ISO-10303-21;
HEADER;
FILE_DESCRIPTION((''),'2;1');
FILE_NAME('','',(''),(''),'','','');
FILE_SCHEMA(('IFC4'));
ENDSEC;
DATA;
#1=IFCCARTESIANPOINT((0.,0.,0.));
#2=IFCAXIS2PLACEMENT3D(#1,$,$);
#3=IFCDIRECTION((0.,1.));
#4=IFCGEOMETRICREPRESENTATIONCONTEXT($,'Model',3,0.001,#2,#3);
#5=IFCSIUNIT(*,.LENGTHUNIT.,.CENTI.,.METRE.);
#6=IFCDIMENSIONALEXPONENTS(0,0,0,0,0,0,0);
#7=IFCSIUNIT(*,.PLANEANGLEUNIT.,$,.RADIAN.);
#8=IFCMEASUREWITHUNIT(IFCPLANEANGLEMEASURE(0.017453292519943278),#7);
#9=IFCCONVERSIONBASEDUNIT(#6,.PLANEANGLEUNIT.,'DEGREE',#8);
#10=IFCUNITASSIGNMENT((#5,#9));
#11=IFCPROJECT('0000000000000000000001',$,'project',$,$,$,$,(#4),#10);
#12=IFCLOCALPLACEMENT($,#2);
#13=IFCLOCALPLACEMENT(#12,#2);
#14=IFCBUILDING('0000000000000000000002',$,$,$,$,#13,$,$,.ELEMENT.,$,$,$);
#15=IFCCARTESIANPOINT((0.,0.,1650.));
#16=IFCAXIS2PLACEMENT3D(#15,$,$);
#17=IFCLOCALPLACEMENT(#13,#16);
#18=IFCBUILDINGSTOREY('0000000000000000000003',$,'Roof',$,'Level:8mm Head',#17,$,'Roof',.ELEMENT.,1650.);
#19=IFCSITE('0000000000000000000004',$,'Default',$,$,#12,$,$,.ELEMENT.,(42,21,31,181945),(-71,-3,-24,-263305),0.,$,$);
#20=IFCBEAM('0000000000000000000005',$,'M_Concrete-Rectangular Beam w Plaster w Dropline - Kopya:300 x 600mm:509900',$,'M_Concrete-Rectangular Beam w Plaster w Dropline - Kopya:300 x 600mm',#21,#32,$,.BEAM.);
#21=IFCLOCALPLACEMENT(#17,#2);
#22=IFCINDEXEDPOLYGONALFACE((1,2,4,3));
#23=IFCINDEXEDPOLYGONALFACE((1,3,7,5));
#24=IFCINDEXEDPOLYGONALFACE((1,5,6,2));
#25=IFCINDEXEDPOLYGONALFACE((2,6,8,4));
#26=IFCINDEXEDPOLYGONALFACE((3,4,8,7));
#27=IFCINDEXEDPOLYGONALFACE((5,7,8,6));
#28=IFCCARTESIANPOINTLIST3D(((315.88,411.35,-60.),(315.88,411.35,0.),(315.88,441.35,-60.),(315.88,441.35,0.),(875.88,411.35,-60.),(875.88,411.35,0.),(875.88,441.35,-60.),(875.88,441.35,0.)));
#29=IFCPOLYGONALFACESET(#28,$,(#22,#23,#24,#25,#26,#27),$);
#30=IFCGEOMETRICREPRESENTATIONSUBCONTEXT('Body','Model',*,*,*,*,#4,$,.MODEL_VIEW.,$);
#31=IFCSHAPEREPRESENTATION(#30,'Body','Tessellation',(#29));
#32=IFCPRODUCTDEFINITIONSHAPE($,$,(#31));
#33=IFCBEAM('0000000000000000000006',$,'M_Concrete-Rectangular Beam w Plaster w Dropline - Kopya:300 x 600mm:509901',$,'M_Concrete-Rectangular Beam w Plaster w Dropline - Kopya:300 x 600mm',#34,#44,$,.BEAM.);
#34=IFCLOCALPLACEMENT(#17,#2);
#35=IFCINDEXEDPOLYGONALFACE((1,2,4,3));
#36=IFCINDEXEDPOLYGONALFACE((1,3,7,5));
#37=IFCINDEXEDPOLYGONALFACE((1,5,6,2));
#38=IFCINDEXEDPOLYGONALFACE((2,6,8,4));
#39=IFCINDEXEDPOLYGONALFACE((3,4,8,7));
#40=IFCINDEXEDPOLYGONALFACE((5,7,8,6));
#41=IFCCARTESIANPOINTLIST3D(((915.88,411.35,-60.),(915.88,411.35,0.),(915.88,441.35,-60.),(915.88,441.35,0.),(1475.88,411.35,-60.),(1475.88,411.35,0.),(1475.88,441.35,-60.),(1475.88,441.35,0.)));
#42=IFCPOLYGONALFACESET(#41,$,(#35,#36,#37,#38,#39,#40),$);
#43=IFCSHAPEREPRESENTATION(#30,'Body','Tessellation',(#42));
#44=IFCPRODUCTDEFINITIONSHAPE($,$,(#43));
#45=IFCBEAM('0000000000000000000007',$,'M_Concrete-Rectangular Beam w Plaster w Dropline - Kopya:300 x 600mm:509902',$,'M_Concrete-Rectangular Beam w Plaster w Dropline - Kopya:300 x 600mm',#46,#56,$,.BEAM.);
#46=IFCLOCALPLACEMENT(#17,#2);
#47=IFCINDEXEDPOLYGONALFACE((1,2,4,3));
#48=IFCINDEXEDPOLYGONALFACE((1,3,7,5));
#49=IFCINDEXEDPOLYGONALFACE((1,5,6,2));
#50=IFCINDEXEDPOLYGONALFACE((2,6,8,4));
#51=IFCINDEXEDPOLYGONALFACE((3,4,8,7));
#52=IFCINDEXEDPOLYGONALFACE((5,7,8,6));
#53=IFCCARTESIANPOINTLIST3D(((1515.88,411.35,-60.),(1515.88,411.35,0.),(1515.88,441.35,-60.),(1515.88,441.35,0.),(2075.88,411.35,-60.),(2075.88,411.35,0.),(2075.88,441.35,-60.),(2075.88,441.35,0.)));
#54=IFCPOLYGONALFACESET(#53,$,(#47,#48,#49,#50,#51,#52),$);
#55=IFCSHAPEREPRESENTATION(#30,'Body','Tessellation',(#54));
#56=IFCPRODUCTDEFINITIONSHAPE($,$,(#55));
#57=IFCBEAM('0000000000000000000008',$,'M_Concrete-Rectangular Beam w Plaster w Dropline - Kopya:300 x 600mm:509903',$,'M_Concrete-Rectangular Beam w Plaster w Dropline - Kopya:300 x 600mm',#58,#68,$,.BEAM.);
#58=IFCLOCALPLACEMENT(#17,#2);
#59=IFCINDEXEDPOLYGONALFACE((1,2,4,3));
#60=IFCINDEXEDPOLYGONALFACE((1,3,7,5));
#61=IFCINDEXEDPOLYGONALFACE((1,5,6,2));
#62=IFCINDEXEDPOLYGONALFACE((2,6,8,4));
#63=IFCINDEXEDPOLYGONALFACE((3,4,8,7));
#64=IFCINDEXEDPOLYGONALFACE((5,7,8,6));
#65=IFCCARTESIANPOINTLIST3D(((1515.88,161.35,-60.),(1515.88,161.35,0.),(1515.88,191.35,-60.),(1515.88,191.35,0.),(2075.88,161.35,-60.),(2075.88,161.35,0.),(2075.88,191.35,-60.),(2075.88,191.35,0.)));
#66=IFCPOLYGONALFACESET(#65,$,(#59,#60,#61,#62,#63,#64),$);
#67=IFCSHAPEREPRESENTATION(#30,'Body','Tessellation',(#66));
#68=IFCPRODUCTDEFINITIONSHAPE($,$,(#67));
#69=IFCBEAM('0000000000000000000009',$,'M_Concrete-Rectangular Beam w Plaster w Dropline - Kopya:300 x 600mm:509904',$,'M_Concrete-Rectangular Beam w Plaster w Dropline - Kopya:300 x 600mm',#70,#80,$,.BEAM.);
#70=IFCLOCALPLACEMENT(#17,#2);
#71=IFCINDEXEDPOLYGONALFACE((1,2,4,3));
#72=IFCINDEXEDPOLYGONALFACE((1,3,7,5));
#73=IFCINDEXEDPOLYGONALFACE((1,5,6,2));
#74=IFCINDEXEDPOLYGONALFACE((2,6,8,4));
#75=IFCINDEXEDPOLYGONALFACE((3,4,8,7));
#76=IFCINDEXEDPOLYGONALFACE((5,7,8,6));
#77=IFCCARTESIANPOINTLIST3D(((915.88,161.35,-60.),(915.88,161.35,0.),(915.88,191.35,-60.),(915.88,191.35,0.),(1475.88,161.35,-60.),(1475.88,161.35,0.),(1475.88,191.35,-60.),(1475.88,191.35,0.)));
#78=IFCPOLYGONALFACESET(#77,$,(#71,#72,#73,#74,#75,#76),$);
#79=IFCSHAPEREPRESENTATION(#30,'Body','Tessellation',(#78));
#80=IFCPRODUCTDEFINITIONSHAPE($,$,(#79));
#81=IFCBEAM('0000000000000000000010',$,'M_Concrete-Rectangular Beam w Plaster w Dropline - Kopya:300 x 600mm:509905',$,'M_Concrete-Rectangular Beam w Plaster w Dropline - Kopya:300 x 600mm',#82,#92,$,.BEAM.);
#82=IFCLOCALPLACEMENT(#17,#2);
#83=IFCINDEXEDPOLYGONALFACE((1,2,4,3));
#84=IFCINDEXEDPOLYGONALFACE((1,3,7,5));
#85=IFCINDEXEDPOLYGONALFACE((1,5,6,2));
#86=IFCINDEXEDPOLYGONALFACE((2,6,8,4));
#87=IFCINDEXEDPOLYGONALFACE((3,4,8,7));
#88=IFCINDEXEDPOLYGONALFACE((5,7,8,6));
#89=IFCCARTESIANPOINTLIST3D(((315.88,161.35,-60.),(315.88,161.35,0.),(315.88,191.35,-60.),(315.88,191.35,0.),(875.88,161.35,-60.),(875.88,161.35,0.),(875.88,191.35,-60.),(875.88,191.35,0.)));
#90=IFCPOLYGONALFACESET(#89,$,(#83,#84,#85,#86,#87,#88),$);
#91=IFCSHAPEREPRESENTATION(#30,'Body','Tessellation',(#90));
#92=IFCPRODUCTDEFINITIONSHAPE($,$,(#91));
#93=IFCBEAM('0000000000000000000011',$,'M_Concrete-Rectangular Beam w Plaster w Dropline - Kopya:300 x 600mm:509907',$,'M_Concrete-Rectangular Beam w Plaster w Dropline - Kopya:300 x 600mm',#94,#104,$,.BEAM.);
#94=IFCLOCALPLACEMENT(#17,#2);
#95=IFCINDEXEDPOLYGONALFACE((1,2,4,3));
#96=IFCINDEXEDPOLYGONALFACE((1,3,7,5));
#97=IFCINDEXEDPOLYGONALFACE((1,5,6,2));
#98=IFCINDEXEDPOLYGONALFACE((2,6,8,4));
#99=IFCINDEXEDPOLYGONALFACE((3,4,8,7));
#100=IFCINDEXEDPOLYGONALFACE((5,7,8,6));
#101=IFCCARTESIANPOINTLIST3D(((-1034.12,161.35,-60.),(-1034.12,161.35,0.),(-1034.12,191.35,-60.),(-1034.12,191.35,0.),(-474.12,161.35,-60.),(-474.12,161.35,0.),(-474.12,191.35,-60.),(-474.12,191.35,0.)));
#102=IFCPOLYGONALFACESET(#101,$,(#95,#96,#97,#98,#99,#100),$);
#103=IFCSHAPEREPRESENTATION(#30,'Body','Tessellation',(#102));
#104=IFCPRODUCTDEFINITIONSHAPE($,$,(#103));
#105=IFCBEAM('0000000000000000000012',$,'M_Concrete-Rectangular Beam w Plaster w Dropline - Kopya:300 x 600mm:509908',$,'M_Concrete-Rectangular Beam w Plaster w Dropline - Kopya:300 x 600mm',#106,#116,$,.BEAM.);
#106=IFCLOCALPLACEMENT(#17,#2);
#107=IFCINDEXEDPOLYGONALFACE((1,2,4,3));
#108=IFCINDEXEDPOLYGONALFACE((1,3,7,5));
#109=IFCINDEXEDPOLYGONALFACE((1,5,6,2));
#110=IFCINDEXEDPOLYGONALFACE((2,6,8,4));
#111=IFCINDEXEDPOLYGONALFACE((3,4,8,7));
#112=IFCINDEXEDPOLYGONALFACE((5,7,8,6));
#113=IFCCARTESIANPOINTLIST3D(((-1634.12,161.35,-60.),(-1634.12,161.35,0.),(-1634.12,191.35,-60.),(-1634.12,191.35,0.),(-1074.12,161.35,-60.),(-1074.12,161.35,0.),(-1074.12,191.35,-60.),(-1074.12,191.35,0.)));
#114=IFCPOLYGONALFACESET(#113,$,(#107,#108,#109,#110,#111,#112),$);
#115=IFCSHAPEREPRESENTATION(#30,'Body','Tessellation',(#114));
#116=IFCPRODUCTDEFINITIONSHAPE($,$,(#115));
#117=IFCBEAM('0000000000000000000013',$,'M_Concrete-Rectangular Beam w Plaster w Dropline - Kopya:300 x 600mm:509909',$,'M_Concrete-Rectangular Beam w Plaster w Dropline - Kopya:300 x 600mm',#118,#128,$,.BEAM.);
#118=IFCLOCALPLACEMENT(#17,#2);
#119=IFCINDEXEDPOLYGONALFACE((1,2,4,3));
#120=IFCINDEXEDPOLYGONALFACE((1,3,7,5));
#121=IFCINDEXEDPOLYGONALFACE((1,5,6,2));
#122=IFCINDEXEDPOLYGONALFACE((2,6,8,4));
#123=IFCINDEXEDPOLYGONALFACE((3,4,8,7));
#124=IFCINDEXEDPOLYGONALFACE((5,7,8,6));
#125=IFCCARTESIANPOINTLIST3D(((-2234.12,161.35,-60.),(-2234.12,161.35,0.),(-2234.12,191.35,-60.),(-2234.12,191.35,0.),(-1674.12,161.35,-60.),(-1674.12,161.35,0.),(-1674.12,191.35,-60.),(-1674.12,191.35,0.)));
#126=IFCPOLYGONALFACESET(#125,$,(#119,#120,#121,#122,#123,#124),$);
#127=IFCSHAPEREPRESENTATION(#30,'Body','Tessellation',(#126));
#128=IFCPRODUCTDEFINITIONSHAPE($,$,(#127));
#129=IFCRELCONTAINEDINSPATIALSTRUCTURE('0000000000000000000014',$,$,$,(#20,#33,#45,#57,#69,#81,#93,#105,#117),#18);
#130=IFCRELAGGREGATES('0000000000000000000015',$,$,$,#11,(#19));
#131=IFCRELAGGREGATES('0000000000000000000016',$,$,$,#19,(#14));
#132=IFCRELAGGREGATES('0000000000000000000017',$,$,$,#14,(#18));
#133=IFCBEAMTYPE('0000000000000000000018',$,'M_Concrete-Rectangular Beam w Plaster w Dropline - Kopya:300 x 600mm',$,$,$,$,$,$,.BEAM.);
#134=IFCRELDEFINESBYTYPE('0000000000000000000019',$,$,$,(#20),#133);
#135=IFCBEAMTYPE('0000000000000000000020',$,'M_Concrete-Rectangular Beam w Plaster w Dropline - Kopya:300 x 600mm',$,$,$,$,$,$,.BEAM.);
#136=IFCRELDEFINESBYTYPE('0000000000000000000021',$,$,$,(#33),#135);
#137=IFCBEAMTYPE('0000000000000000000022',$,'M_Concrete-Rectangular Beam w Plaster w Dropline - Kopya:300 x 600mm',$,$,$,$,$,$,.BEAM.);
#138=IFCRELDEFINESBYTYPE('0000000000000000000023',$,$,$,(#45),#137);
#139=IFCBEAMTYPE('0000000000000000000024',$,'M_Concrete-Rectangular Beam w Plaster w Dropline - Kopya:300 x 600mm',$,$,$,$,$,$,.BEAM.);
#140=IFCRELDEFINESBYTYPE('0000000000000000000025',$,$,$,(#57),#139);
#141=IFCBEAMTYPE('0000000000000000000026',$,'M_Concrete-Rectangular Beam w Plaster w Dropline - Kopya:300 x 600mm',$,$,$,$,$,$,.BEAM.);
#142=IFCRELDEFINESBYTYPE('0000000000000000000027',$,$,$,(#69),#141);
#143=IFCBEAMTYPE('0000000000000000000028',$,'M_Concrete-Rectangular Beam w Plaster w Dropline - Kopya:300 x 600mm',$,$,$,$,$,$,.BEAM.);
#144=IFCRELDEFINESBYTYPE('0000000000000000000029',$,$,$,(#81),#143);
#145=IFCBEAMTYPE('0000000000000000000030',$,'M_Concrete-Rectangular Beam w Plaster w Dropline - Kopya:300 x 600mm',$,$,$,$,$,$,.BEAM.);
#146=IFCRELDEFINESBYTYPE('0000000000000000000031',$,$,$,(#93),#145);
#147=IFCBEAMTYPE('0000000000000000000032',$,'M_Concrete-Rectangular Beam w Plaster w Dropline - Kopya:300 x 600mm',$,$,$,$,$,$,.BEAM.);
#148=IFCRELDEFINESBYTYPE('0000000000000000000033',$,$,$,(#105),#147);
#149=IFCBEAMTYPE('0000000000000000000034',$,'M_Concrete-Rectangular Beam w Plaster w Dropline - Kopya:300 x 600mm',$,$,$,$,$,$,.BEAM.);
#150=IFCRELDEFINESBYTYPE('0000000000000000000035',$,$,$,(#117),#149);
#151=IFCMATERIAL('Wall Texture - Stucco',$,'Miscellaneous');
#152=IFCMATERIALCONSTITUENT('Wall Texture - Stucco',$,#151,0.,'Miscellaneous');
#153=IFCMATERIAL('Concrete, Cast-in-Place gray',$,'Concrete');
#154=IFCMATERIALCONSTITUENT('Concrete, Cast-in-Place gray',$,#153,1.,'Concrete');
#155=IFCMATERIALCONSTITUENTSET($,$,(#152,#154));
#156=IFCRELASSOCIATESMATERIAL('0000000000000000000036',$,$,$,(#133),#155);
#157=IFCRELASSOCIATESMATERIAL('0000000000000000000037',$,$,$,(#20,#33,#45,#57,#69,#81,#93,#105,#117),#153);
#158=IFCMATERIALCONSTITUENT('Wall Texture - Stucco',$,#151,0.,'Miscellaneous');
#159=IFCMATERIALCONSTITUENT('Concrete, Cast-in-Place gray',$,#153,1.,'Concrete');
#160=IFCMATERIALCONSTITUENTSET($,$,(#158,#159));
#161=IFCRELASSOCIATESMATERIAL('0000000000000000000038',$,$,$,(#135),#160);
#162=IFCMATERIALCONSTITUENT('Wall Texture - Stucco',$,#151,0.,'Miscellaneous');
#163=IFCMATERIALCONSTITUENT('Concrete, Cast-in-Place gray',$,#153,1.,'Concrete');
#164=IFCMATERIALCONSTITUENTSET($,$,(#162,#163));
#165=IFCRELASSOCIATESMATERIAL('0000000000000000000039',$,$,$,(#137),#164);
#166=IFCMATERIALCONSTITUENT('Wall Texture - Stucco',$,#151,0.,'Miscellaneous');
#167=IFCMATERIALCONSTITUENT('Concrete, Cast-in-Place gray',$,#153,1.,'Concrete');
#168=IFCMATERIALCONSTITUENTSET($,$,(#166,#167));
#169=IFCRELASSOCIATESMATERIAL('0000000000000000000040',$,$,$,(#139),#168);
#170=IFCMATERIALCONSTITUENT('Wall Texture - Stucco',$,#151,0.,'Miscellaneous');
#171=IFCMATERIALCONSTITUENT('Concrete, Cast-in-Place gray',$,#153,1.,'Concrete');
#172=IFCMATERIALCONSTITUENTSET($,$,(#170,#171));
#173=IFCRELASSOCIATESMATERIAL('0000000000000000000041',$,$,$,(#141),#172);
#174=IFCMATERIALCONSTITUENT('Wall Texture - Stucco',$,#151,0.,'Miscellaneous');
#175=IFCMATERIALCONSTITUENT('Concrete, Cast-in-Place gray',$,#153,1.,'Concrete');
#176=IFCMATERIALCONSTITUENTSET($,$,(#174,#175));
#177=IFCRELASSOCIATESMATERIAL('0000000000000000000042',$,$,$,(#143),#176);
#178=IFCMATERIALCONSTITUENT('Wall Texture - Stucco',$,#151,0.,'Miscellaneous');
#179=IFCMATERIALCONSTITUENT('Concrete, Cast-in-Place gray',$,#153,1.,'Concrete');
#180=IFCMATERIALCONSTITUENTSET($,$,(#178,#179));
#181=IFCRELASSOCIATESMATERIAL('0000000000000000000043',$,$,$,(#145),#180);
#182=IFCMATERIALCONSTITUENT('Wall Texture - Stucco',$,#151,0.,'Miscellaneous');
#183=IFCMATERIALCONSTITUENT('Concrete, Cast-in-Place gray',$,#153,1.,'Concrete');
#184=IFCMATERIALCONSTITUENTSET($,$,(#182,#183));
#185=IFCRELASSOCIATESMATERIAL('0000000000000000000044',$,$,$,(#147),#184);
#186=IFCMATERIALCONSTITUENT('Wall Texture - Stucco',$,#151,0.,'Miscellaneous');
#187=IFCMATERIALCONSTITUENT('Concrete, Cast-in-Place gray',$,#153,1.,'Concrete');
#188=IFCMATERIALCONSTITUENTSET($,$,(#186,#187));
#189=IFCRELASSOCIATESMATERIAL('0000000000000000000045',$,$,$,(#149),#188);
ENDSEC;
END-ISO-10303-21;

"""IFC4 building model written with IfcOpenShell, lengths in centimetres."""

from ifc_helpers import new_model, entity, si_unit, converted_unit, direction, frame, origin, place, context, subcontext, project, spatial, indexed_curve, outline, extrude, source, transform, mapped, material, constituent, constituent_set, type_object, type_shapes, element, save


model = new_model("IFC4")

# Units and contexts
model_context = context("Model", 3, precision=0.001, world=origin(), true_north=direction((0.0, 1.0)))
body_context = subcontext(model_context, "Body", "Model", "MODEL_VIEW")
ifc_project = project(units=[si_unit("LENGTHUNIT", "METRE", prefix="CENTI"), converted_unit("PLANEANGLEUNIT", "DEGREE", entity("IfcPlaneAngleMeasure", 0.017453292519943278), si_unit("PLANEANGLEUNIT", "RADIAN"), dimensions=[0, 0, 0, 0, 0, 0, 0])], contexts=[model_context])

# Site, building, storey
site_placement = place(None, origin())
site = spatial("IfcSite", under=ifc_project, at=site_placement, Name="Default", CompositionType="ELEMENT", RefLatitude=(42, 21, 31, 181945), RefLongitude=(-71, -3, -24, -263305), RefElevation=0.0)
building_placement = place(site_placement, origin())
building = spatial("IfcBuilding", under=site, at=building_placement, CompositionType="ELEMENT")
storey_placement = place(building_placement, frame((0.0, 0.0, 1650.0)))
storey = spatial("IfcBuildingStorey", under=building, at=storey_placement, Name="Roof", ObjectType="Level:8mm Head", LongName="Roof", CompositionType="ELEMENT", Elevation=1650.0)

# Beams
ifc_material_1 = material(Name="Concrete, Cast-in-Place gray", Category="Concrete")
ifc_material_2 = material(Name="Wall Texture - Stucco", Category="Miscellaneous")
ifc_constituent_1 = constituent(ifc_material_2, Name="Wall Texture - Stucco", Category="Miscellaneous", fraction=0.0)
ifc_constituent_2 = constituent(ifc_material_1, Name="Concrete, Cast-in-Place gray", Category="Concrete", fraction=1.0)
ifc_constituent_set_1 = constituent_set(constituents=[ifc_constituent_1, ifc_constituent_2])
beam_type_1 = type_object("IfcBeamType", Name="M_Concrete-Rectangular Beam w Plaster w Dropline - Kopya:300 x 600mm", PredefinedType="BEAM", material=ifc_constituent_set_1)
shared_shape_1 = source(origin(), body_context, "Body", "SweptSolid", [
    extrude(outline(indexed_curve([(-30.0, -15.0), (30.0, -15.0), (30.0, 15.0), (-30.0, 15.0), (-30.0, -15.0)], self_intersect=False)), frame((315.88, 426.35, 1620.0), z_axis=(1.0, 0.0, 0.0), x_axis=(0.0, 0.0, -1.0)), (0.0, 0.0, 1.0), 560.0),
])
type_shapes(beam_type_1, [shared_shape_1])
beam_1_placement = place(storey_placement, frame((0.0, 0.0, -1650.0)))
element("IfcBeam", 1, at=beam_1_placement, inside=storey, type_object=beam_type_1, material=ifc_material_1, Name="M_Concrete-Rectangular Beam w Plaster w Dropline - Kopya:300 x 600mm:509900", ObjectType="M_Concrete-Rectangular Beam w Plaster w Dropline - Kopya:300 x 600mm", PredefinedType="BEAM", context=body_context, shape_type="MappedRepresentation", body=[
    mapped(shared_shape_1, transform((0.0, 0.0, 0.0), scale=1.0)),
])
ifc_constituent_3 = constituent(ifc_material_2, Name="Wall Texture - Stucco", Category="Miscellaneous", fraction=0.0)
ifc_constituent_4 = constituent(ifc_material_1, Name="Concrete, Cast-in-Place gray", Category="Concrete", fraction=1.0)
ifc_constituent_set_2 = constituent_set(constituents=[ifc_constituent_3, ifc_constituent_4])
beam_type_2 = type_object("IfcBeamType", Name="M_Concrete-Rectangular Beam w Plaster w Dropline - Kopya:300 x 600mm", PredefinedType="BEAM", material=ifc_constituent_set_2)
shared_shape_2 = source(origin(), body_context, "Body", "SweptSolid", [
    extrude(outline(indexed_curve([(-30.0, -15.0), (30.0, -15.0), (30.0, 15.0), (-30.0, 15.0), (-30.0, -15.0)], self_intersect=False)), frame((915.88, 426.35, 1620.0), z_axis=(1.0, 0.0, 0.0), x_axis=(0.0, 0.0, -1.0)), (0.0, 0.0, 1.0), 560.0),
])
type_shapes(beam_type_2, [shared_shape_2])
beam_2_placement = place(storey_placement, frame((0.0, 0.0, -1650.0)))
element("IfcBeam", 2, at=beam_2_placement, inside=storey, type_object=beam_type_2, material=ifc_material_1, Name="M_Concrete-Rectangular Beam w Plaster w Dropline - Kopya:300 x 600mm:509901", ObjectType="M_Concrete-Rectangular Beam w Plaster w Dropline - Kopya:300 x 600mm", PredefinedType="BEAM", context=body_context, shape_type="MappedRepresentation", body=[
    mapped(shared_shape_2, transform((0.0, 0.0, 0.0), scale=1.0)),
])
ifc_constituent_5 = constituent(ifc_material_2, Name="Wall Texture - Stucco", Category="Miscellaneous", fraction=0.0)
ifc_constituent_6 = constituent(ifc_material_1, Name="Concrete, Cast-in-Place gray", Category="Concrete", fraction=1.0)
ifc_constituent_set_3 = constituent_set(constituents=[ifc_constituent_5, ifc_constituent_6])
beam_type_3 = type_object("IfcBeamType", Name="M_Concrete-Rectangular Beam w Plaster w Dropline - Kopya:300 x 600mm", PredefinedType="BEAM", material=ifc_constituent_set_3)
shared_shape_3 = source(origin(), body_context, "Body", "SweptSolid", [
    extrude(outline(indexed_curve([(-30.0, -15.0), (30.0, -15.0), (30.0, 15.0), (-30.0, 15.0), (-30.0, -15.0)], self_intersect=False)), frame((1515.88, 426.35, 1620.0), z_axis=(1.0, 0.0, 0.0), x_axis=(0.0, 0.0, -1.0)), (0.0, 0.0, 1.0), 560.0),
])
type_shapes(beam_type_3, [shared_shape_3])
beam_3_placement = place(storey_placement, frame((0.0, 0.0, -1650.0)))
element("IfcBeam", 3, at=beam_3_placement, inside=storey, type_object=beam_type_3, material=ifc_material_1, Name="M_Concrete-Rectangular Beam w Plaster w Dropline - Kopya:300 x 600mm:509902", ObjectType="M_Concrete-Rectangular Beam w Plaster w Dropline - Kopya:300 x 600mm", PredefinedType="BEAM", context=body_context, shape_type="MappedRepresentation", body=[
    mapped(shared_shape_3, transform((0.0, 0.0, 0.0), scale=1.0)),
])
ifc_constituent_7 = constituent(ifc_material_2, Name="Wall Texture - Stucco", Category="Miscellaneous", fraction=0.0)
ifc_constituent_8 = constituent(ifc_material_1, Name="Concrete, Cast-in-Place gray", Category="Concrete", fraction=1.0)
ifc_constituent_set_4 = constituent_set(constituents=[ifc_constituent_7, ifc_constituent_8])
beam_type_4 = type_object("IfcBeamType", Name="M_Concrete-Rectangular Beam w Plaster w Dropline - Kopya:300 x 600mm", PredefinedType="BEAM", material=ifc_constituent_set_4)
shared_shape_4 = source(origin(), body_context, "Body", "SweptSolid", [
    extrude(outline(indexed_curve([(-30.0, -15.0), (30.0, -15.0), (30.0, 15.0), (-30.0, 15.0), (-30.0, -15.0)], self_intersect=False)), frame((2075.88, 176.35, 1620.0), z_axis=(-1.0, 0.0, 0.0), x_axis=(0.0, 0.0, -1.0)), (0.0, 0.0, 1.0), 560.0),
])
type_shapes(beam_type_4, [shared_shape_4])
beam_4_placement = place(storey_placement, frame((0.0, 0.0, -1650.0)))
element("IfcBeam", 4, at=beam_4_placement, inside=storey, type_object=beam_type_4, material=ifc_material_1, Name="M_Concrete-Rectangular Beam w Plaster w Dropline - Kopya:300 x 600mm:509903", ObjectType="M_Concrete-Rectangular Beam w Plaster w Dropline - Kopya:300 x 600mm", PredefinedType="BEAM", context=body_context, shape_type="MappedRepresentation", body=[
    mapped(shared_shape_4, transform((0.0, 0.0, 0.0), scale=1.0)),
])
ifc_constituent_9 = constituent(ifc_material_2, Name="Wall Texture - Stucco", Category="Miscellaneous", fraction=0.0)
ifc_constituent_10 = constituent(ifc_material_1, Name="Concrete, Cast-in-Place gray", Category="Concrete", fraction=1.0)
ifc_constituent_set_5 = constituent_set(constituents=[ifc_constituent_9, ifc_constituent_10])
beam_type_5 = type_object("IfcBeamType", Name="M_Concrete-Rectangular Beam w Plaster w Dropline - Kopya:300 x 600mm", PredefinedType="BEAM", material=ifc_constituent_set_5)
shared_shape_5 = source(origin(), body_context, "Body", "SweptSolid", [
    extrude(outline(indexed_curve([(-30.0, -15.0), (30.0, -15.0), (30.0, 15.0), (-30.0, 15.0), (-30.0, -15.0)], self_intersect=False)), frame((1475.88, 176.35, 1620.0), z_axis=(-1.0, 0.0, 0.0), x_axis=(0.0, 0.0, -1.0)), (0.0, 0.0, 1.0), 560.0),
])
type_shapes(beam_type_5, [shared_shape_5])
beam_5_placement = place(storey_placement, frame((0.0, 0.0, -1650.0)))
element("IfcBeam", 5, at=beam_5_placement, inside=storey, type_object=beam_type_5, material=ifc_material_1, Name="M_Concrete-Rectangular Beam w Plaster w Dropline - Kopya:300 x 600mm:509904", ObjectType="M_Concrete-Rectangular Beam w Plaster w Dropline - Kopya:300 x 600mm", PredefinedType="BEAM", context=body_context, shape_type="MappedRepresentation", body=[
    mapped(shared_shape_5, transform((0.0, 0.0, 0.0), scale=1.0)),
])
ifc_constituent_11 = constituent(ifc_material_2, Name="Wall Texture - Stucco", Category="Miscellaneous", fraction=0.0)
ifc_constituent_12 = constituent(ifc_material_1, Name="Concrete, Cast-in-Place gray", Category="Concrete", fraction=1.0)
ifc_constituent_set_6 = constituent_set(constituents=[ifc_constituent_11, ifc_constituent_12])
beam_type_6 = type_object("IfcBeamType", Name="M_Concrete-Rectangular Beam w Plaster w Dropline - Kopya:300 x 600mm", PredefinedType="BEAM", material=ifc_constituent_set_6)
shared_shape_6 = source(origin(), body_context, "Body", "SweptSolid", [
    extrude(outline(indexed_curve([(-30.0, -15.0), (30.0, -15.0), (30.0, 15.0), (-30.0, 15.0), (-30.0, -15.0)], self_intersect=False)), frame((875.88, 176.35, 1620.0), z_axis=(-1.0, 0.0, 0.0), x_axis=(0.0, 0.0, -1.0)), (0.0, 0.0, 1.0), 560.0),
])
type_shapes(beam_type_6, [shared_shape_6])
beam_6_placement = place(storey_placement, frame((0.0, 0.0, -1650.0)))
element("IfcBeam", 6, at=beam_6_placement, inside=storey, type_object=beam_type_6, material=ifc_material_1, Name="M_Concrete-Rectangular Beam w Plaster w Dropline - Kopya:300 x 600mm:509905", ObjectType="M_Concrete-Rectangular Beam w Plaster w Dropline - Kopya:300 x 600mm", PredefinedType="BEAM", context=body_context, shape_type="MappedRepresentation", body=[
    mapped(shared_shape_6, transform((0.0, 0.0, 0.0), scale=1.0)),
])
ifc_constituent_13 = constituent(ifc_material_2, Name="Wall Texture - Stucco", Category="Miscellaneous", fraction=0.0)
ifc_constituent_14 = constituent(ifc_material_1, Name="Concrete, Cast-in-Place gray", Category="Concrete", fraction=1.0)
ifc_constituent_set_7 = constituent_set(constituents=[ifc_constituent_13, ifc_constituent_14])
beam_type_7 = type_object("IfcBeamType", Name="M_Concrete-Rectangular Beam w Plaster w Dropline - Kopya:300 x 600mm", PredefinedType="BEAM", material=ifc_constituent_set_7)
shared_shape_7 = source(origin(), body_context, "Body", "SweptSolid", [
    extrude(outline(indexed_curve([(-30.0, -15.0), (30.0, -15.0), (30.0, 15.0), (-30.0, 15.0), (-30.0, -15.0)], self_intersect=False)), frame((-474.12, 176.35, 1620.0), z_axis=(-1.0, 0.0, 0.0), x_axis=(0.0, 0.0, -1.0)), (0.0, 0.0, 1.0), 560.0),
])
type_shapes(beam_type_7, [shared_shape_7])
beam_7_placement = place(storey_placement, frame((0.0, 0.0, -1650.0)))
element("IfcBeam", 7, at=beam_7_placement, inside=storey, type_object=beam_type_7, material=ifc_material_1, Name="M_Concrete-Rectangular Beam w Plaster w Dropline - Kopya:300 x 600mm:509907", ObjectType="M_Concrete-Rectangular Beam w Plaster w Dropline - Kopya:300 x 600mm", PredefinedType="BEAM", context=body_context, shape_type="MappedRepresentation", body=[
    mapped(shared_shape_7, transform((0.0, 0.0, 0.0), scale=1.0)),
])
ifc_constituent_15 = constituent(ifc_material_2, Name="Wall Texture - Stucco", Category="Miscellaneous", fraction=0.0)
ifc_constituent_16 = constituent(ifc_material_1, Name="Concrete, Cast-in-Place gray", Category="Concrete", fraction=1.0)
ifc_constituent_set_8 = constituent_set(constituents=[ifc_constituent_15, ifc_constituent_16])
beam_type_8 = type_object("IfcBeamType", Name="M_Concrete-Rectangular Beam w Plaster w Dropline - Kopya:300 x 600mm", PredefinedType="BEAM", material=ifc_constituent_set_8)
shared_shape_8 = source(origin(), body_context, "Body", "SweptSolid", [
    extrude(outline(indexed_curve([(-30.0, -15.0), (30.0, -15.0), (30.0, 15.0), (-30.0, 15.0), (-30.0, -15.0)], self_intersect=False)), frame((-1074.12, 176.35, 1620.0), z_axis=(-1.0, 0.0, 0.0), x_axis=(0.0, 0.0, -1.0)), (0.0, 0.0, 1.0), 560.0),
])
type_shapes(beam_type_8, [shared_shape_8])
beam_8_placement = place(storey_placement, frame((0.0, 0.0, -1650.0)))
element("IfcBeam", 8, at=beam_8_placement, inside=storey, type_object=beam_type_8, material=ifc_material_1, Name="M_Concrete-Rectangular Beam w Plaster w Dropline - Kopya:300 x 600mm:509908", ObjectType="M_Concrete-Rectangular Beam w Plaster w Dropline - Kopya:300 x 600mm", PredefinedType="BEAM", context=body_context, shape_type="MappedRepresentation", body=[
    mapped(shared_shape_8, transform((0.0, 0.0, 0.0), scale=1.0)),
])
ifc_constituent_17 = constituent(ifc_material_2, Name="Wall Texture - Stucco", Category="Miscellaneous", fraction=0.0)
ifc_constituent_18 = constituent(ifc_material_1, Name="Concrete, Cast-in-Place gray", Category="Concrete", fraction=1.0)
ifc_constituent_set_9 = constituent_set(constituents=[ifc_constituent_17, ifc_constituent_18])
beam_type_9 = type_object("IfcBeamType", Name="M_Concrete-Rectangular Beam w Plaster w Dropline - Kopya:300 x 600mm", PredefinedType="BEAM", material=ifc_constituent_set_9)
shared_shape_9 = source(origin(), body_context, "Body", "SweptSolid", [
    extrude(outline(indexed_curve([(-30.0, -15.0), (30.0, -15.0), (30.0, 15.0), (-30.0, 15.0), (-30.0, -15.0)], self_intersect=False)), frame((-1674.12, 176.35, 1620.0), z_axis=(-1.0, 0.0, 0.0), x_axis=(0.0, 0.0, -1.0)), (0.0, 0.0, 1.0), 560.0),
])
type_shapes(beam_type_9, [shared_shape_9])
beam_9_placement = place(storey_placement, frame((0.0, 0.0, -1650.0)))
element("IfcBeam", 9, at=beam_9_placement, inside=storey, type_object=beam_type_9, material=ifc_material_1, Name="M_Concrete-Rectangular Beam w Plaster w Dropline - Kopya:300 x 600mm:509909", ObjectType="M_Concrete-Rectangular Beam w Plaster w Dropline - Kopya:300 x 600mm", PredefinedType="BEAM", context=body_context, shape_type="MappedRepresentation", body=[
    mapped(shared_shape_9, transform((0.0, 0.0, 0.0), scale=1.0)),
])

save(model, "model.ifc")
